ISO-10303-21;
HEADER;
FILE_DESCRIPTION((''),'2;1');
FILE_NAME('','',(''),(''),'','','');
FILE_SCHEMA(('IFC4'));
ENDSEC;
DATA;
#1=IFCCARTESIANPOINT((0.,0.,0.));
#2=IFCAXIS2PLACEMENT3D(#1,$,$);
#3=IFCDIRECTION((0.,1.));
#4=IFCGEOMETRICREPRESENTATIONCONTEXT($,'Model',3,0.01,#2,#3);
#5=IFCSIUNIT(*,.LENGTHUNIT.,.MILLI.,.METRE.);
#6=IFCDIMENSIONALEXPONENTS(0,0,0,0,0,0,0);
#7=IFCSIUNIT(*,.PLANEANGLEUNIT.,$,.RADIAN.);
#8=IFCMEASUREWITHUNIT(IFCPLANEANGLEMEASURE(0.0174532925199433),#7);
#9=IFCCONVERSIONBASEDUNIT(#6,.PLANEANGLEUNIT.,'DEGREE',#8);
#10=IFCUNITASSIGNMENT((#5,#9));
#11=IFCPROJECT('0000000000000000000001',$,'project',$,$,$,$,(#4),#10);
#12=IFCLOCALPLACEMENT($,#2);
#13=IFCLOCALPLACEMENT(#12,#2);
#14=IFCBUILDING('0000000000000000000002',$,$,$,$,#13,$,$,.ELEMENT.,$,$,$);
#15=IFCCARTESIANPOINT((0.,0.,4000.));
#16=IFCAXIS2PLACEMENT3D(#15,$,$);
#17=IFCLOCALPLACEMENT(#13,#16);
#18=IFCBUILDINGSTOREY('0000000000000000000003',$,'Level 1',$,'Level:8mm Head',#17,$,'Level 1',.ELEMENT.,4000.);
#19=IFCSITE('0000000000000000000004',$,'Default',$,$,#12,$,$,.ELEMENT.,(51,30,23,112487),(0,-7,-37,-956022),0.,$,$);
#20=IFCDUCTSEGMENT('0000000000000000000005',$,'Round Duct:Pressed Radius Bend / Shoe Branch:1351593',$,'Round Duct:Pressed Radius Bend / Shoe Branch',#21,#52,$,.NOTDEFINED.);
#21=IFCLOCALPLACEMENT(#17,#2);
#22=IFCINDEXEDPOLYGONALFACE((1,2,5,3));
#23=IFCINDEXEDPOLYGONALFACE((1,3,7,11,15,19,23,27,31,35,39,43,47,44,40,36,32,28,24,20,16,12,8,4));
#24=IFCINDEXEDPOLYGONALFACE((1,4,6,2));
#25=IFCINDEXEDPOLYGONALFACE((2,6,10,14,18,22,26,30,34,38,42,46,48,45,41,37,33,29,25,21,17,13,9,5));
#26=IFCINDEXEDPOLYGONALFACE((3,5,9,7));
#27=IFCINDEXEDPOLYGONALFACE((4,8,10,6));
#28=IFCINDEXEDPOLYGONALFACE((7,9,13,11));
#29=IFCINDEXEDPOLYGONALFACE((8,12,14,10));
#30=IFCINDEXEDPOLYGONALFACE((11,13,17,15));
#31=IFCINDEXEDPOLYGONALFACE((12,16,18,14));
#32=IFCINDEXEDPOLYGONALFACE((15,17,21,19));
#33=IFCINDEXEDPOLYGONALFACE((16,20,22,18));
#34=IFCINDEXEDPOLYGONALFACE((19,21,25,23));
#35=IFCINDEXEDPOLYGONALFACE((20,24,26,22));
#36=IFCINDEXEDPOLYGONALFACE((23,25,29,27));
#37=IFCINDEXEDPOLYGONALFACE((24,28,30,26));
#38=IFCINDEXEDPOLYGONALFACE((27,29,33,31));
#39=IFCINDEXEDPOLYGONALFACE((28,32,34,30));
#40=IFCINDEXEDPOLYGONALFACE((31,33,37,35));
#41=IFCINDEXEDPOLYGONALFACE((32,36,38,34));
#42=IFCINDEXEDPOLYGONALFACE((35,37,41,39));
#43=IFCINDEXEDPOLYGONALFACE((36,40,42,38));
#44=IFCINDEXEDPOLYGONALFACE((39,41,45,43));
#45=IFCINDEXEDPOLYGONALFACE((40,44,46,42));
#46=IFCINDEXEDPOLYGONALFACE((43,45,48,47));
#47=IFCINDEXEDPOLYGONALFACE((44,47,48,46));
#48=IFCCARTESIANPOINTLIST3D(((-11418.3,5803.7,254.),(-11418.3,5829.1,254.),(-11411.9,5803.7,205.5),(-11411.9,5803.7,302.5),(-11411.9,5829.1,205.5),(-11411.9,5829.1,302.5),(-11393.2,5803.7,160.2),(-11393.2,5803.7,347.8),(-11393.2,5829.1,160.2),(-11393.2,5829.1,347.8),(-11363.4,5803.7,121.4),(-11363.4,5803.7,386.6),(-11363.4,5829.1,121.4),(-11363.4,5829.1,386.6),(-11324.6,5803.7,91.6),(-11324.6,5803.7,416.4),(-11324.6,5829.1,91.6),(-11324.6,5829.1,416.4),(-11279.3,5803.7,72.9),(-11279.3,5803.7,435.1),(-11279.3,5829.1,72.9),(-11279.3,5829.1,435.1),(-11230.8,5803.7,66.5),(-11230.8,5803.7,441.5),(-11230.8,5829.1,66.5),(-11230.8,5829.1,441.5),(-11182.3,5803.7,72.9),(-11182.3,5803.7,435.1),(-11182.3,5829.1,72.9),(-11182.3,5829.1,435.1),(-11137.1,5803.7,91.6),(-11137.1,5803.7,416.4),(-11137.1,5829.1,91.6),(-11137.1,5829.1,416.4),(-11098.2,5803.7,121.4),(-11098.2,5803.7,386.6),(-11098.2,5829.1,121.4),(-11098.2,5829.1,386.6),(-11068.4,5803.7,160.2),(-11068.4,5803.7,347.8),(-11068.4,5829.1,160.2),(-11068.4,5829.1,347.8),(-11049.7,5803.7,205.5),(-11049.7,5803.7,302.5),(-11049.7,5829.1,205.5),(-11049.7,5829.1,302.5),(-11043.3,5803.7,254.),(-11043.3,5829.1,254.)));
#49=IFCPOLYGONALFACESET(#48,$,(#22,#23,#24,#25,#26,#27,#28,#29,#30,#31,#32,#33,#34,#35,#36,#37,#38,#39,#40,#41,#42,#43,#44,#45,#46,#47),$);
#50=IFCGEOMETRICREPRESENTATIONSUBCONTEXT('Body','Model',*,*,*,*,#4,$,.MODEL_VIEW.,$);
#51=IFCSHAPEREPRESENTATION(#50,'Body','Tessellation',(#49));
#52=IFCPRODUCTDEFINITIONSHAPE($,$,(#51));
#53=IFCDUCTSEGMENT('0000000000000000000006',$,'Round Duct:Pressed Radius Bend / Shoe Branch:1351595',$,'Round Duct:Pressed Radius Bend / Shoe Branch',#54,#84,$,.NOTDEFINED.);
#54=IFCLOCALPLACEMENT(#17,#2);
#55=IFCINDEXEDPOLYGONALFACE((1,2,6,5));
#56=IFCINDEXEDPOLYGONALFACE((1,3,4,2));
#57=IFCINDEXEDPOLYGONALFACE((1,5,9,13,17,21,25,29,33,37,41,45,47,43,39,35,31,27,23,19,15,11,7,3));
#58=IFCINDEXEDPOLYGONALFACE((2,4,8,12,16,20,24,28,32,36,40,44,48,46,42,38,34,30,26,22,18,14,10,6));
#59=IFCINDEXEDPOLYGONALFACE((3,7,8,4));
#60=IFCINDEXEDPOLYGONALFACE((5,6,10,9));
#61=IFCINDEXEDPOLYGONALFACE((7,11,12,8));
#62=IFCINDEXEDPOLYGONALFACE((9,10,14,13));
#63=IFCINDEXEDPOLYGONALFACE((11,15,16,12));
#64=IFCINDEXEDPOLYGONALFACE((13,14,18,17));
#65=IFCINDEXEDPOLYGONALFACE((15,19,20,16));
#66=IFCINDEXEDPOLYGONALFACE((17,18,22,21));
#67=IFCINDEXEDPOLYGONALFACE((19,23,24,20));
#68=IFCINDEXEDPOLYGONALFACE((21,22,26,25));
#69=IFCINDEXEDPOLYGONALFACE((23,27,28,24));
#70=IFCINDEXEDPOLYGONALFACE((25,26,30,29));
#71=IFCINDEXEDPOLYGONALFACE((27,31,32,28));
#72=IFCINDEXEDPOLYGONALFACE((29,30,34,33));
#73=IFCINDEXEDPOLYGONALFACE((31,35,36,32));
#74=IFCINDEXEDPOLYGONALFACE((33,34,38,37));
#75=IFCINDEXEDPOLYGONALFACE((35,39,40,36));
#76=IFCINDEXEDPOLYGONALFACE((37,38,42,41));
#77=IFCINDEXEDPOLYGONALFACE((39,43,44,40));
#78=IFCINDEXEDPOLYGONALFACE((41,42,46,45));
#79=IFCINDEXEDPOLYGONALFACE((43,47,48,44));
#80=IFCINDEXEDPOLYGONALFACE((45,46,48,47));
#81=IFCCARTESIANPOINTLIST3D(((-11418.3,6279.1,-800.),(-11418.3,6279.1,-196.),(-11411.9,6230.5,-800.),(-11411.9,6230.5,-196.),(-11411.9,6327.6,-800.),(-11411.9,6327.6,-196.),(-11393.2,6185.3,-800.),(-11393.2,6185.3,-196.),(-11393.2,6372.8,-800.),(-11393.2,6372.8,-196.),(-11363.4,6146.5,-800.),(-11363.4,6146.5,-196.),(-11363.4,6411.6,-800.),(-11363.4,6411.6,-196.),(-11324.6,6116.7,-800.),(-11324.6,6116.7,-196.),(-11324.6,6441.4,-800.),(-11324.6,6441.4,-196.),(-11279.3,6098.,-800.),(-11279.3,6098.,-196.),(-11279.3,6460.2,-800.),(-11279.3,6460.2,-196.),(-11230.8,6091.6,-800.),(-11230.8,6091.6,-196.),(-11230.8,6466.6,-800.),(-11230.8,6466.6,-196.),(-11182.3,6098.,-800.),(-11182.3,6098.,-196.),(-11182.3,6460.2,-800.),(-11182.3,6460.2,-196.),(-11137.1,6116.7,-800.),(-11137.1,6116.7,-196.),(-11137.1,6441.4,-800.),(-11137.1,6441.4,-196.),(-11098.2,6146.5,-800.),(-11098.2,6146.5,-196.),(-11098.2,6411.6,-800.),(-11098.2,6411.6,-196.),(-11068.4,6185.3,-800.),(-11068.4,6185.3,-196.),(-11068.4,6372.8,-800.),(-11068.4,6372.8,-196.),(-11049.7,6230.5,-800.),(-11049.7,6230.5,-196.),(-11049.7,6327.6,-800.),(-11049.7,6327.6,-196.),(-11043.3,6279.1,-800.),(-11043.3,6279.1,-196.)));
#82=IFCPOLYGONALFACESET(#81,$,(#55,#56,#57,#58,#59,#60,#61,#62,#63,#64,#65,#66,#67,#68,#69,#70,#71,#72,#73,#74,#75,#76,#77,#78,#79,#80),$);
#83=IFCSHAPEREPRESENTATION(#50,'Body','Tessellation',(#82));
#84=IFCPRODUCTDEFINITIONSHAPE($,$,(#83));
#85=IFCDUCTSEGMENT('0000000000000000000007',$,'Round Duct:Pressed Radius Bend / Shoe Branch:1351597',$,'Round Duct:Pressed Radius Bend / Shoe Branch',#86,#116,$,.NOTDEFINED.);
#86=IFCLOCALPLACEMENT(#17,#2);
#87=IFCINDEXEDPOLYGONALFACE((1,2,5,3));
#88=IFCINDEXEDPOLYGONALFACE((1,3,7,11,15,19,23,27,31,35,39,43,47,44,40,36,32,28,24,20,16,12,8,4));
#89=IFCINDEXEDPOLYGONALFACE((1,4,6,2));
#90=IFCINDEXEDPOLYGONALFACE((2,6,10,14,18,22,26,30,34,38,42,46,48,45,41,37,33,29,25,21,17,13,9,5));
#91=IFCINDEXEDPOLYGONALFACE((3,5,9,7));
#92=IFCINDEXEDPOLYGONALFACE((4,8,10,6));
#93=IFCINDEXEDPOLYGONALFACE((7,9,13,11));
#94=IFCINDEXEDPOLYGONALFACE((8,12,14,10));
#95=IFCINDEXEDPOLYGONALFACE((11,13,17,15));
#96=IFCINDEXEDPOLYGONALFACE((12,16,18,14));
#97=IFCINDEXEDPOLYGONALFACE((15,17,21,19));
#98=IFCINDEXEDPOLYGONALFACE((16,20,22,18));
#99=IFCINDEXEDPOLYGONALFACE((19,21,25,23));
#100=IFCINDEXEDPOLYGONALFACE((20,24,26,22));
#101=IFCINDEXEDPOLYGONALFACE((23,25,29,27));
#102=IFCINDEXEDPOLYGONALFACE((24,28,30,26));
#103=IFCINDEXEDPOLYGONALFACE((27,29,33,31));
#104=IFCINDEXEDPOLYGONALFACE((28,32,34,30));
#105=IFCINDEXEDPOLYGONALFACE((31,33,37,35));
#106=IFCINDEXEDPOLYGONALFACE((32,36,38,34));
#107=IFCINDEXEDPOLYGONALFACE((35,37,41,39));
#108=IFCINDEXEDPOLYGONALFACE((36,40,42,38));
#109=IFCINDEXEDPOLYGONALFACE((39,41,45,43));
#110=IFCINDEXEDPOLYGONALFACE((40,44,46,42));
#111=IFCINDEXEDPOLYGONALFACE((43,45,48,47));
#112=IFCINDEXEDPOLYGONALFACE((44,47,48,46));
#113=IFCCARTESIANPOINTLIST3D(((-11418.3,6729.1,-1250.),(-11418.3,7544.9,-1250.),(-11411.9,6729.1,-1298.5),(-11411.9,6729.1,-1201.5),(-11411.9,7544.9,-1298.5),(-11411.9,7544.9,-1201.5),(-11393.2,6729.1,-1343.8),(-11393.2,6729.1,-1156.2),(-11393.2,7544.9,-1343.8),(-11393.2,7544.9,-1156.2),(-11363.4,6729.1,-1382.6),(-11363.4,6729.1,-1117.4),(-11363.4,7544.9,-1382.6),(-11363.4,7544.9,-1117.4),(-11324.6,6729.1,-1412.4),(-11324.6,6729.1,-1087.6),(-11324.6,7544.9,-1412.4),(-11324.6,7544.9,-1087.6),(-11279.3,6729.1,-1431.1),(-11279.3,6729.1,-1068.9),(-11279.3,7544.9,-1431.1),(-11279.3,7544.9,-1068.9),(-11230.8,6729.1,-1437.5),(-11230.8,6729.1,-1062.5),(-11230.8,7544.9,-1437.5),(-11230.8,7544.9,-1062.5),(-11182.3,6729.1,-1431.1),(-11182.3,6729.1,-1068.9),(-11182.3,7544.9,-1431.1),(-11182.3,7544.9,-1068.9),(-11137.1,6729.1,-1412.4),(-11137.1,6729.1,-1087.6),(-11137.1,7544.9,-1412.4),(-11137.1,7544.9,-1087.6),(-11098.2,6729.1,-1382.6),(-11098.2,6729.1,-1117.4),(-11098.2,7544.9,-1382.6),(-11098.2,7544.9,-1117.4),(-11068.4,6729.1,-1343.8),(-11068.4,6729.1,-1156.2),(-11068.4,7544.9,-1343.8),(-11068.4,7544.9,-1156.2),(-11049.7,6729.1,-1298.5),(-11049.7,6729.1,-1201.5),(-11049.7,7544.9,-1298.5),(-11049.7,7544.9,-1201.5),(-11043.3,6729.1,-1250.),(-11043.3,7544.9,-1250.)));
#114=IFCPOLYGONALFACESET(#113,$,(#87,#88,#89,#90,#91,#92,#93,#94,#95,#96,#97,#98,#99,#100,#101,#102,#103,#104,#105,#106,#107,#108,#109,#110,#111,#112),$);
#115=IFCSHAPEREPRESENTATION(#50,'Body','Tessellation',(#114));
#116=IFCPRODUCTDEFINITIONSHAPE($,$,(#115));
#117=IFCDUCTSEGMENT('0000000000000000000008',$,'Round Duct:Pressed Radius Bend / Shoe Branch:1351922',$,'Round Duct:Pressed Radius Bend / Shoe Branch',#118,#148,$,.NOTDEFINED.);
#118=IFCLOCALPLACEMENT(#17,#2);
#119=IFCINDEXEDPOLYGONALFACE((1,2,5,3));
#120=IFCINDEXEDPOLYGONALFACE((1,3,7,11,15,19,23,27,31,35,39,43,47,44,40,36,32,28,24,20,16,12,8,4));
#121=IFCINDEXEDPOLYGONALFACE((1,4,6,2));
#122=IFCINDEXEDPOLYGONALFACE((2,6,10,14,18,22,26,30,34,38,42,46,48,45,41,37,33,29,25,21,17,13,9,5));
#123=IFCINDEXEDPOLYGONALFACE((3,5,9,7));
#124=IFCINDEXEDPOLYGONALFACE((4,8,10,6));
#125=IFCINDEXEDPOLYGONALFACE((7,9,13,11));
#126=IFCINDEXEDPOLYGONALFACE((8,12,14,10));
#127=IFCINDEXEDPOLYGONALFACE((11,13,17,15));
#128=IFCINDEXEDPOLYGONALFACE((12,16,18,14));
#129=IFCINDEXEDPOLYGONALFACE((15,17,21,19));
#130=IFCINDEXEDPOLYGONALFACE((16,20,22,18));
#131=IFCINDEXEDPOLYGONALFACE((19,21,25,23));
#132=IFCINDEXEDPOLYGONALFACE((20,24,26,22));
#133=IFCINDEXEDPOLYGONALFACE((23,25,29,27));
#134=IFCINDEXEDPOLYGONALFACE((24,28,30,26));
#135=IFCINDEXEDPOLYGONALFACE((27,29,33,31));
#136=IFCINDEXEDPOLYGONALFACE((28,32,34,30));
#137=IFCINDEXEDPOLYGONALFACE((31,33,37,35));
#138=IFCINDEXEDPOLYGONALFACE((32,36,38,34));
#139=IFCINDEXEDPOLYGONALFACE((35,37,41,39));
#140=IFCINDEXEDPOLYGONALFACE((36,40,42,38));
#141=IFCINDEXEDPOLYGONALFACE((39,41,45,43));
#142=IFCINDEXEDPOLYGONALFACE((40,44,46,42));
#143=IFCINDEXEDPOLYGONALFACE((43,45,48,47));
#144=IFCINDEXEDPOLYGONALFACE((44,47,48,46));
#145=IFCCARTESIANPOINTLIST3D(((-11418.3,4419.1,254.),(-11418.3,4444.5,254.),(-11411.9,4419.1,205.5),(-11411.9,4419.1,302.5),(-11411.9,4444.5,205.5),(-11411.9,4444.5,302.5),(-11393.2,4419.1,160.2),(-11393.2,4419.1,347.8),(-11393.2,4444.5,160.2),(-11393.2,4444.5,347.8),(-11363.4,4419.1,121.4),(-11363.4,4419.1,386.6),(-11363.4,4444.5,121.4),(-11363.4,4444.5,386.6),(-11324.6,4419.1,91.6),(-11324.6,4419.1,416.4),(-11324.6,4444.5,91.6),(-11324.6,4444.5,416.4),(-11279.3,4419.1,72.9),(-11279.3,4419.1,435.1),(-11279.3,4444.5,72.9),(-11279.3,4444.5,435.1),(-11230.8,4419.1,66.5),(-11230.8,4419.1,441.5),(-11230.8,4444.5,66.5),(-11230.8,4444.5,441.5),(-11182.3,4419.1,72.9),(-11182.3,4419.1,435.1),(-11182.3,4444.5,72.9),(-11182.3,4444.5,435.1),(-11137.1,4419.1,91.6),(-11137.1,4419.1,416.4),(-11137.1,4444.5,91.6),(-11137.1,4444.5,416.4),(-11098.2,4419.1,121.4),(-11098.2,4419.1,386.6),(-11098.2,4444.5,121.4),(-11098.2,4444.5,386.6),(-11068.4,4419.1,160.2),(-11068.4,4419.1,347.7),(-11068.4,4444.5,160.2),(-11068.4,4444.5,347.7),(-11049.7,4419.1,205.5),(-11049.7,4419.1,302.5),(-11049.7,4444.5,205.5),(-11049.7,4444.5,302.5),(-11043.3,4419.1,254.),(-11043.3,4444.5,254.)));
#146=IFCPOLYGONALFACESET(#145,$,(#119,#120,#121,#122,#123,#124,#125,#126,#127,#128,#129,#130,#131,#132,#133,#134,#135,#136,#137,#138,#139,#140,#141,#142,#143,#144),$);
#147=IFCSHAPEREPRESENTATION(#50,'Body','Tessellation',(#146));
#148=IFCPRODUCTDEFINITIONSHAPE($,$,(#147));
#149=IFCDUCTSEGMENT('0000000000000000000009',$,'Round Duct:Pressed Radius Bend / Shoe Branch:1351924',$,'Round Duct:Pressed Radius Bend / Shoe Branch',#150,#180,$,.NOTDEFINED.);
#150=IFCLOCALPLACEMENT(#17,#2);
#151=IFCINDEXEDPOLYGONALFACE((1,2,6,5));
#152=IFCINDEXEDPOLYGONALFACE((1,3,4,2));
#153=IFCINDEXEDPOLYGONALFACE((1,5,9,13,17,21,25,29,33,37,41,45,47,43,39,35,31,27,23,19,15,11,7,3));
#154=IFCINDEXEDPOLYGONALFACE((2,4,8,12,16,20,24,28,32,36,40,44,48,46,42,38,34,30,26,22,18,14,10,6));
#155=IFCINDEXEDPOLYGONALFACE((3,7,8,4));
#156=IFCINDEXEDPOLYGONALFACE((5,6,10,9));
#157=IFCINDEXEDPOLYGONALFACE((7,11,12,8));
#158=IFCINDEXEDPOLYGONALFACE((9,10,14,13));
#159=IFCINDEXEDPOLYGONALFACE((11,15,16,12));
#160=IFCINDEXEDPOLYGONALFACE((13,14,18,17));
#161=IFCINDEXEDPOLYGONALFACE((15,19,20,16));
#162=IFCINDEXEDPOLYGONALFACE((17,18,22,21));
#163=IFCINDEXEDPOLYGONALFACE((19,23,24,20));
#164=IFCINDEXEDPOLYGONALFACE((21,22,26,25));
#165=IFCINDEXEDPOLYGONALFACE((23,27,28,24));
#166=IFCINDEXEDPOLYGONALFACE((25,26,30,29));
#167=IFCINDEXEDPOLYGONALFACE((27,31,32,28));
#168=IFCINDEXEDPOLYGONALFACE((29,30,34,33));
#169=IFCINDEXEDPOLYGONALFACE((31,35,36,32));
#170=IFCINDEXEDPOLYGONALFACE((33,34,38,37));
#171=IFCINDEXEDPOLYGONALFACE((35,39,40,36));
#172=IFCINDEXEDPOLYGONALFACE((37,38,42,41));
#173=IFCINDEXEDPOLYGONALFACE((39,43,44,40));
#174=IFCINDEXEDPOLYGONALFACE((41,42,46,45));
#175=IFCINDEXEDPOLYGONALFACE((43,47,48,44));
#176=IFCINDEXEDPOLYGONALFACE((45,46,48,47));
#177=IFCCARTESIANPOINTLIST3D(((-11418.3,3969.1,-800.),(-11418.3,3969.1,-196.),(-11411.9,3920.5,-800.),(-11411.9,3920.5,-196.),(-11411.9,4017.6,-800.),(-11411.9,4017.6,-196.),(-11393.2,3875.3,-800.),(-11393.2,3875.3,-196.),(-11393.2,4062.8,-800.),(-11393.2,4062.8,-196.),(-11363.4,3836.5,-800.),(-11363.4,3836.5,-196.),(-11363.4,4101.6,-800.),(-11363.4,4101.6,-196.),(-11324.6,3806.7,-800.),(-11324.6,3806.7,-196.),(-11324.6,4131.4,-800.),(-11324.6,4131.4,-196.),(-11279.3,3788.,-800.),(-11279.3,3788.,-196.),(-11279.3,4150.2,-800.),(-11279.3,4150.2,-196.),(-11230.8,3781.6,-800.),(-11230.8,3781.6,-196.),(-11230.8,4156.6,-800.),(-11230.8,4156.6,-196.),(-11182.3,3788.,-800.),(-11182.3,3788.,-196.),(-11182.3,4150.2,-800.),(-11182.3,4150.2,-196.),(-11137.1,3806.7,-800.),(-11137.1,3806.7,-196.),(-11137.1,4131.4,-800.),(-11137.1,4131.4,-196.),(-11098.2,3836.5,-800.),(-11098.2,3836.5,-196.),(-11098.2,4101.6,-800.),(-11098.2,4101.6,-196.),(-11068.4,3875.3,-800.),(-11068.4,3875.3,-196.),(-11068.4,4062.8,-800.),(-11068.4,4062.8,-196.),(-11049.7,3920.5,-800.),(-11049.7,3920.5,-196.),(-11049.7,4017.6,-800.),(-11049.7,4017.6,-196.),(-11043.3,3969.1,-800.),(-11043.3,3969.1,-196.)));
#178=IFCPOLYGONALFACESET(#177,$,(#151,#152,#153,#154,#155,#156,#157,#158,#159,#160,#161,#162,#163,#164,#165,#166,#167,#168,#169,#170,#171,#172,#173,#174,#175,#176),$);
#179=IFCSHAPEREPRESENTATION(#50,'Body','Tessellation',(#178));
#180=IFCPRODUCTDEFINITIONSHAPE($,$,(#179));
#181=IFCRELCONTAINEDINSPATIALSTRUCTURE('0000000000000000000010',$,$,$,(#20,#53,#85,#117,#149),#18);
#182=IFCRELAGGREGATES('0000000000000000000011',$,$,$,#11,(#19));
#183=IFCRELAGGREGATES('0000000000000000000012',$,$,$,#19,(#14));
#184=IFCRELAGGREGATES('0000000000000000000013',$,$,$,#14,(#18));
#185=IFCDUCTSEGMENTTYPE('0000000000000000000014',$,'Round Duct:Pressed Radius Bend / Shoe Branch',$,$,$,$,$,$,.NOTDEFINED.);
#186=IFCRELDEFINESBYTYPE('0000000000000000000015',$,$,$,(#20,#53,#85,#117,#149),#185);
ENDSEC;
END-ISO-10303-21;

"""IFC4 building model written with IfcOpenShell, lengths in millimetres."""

from ifc_helpers import new_model, entity, si_unit, converted_unit, direction, frame, origin, place, context, subcontext, project, spatial, arc, indexed_curve, outline, extrude, type_object, element, save


model = new_model("IFC4")

# Units and contexts
model_context = context("Model", 3, precision=0.01, world=origin(), true_north=direction((0.0, 1.0)))
body_context = subcontext(model_context, "Body", "Model", "MODEL_VIEW")
ifc_project = project(units=[si_unit("LENGTHUNIT", "METRE", prefix="MILLI"), converted_unit("PLANEANGLEUNIT", "DEGREE", entity("IfcPlaneAngleMeasure", 0.0174532925199433), si_unit("PLANEANGLEUNIT", "RADIAN"), dimensions=[0, 0, 0, 0, 0, 0, 0])], contexts=[model_context])

# Site, building, storey
site_placement = place(None, origin())
site = spatial("IfcSite", under=ifc_project, at=site_placement, Name="Default", CompositionType="ELEMENT", RefLatitude=(51, 30, 23, 112487), RefLongitude=(0, -7, -37, -956022), RefElevation=0.0)
building_placement = place(site_placement, origin())
building = spatial("IfcBuilding", under=site, at=building_placement, CompositionType="ELEMENT")
storey_placement = place(building_placement, frame((0.0, 0.0, 4000.0)))
storey = spatial("IfcBuildingStorey", under=building, at=storey_placement, Name="Level 1", ObjectType="Level:8mm Head", LongName="Level 1", CompositionType="ELEMENT", Elevation=4000.0)

# Duct segments
duct_segment_type = type_object("IfcDuctSegmentType", Name="Round Duct:Pressed Radius Bend / Shoe Branch", PredefinedType="NOTDEFINED")
duct_segment_1_placement = place(storey_placement, origin())
element("IfcDuctSegment", 1, at=duct_segment_1_placement, inside=storey, type_object=duct_segment_type, Name="Round Duct:Pressed Radius Bend / Shoe Branch:1351593", ObjectType="Round Duct:Pressed Radius Bend / Shoe Branch", PredefinedType="NOTDEFINED", context=body_context, shape_type="SweptSolid", body=[
    extrude(outline(indexed_curve([(187.5, 0.0), (132.6, 132.6), (0.0, 187.5), (-132.6, 132.6), (-187.5, 0.0), (-132.6, -132.6), (0.0, -187.5), (132.6, -132.6)], segments=[arc(1, 2, 3), arc(3, 4, 5), arc(5, 6, 7), arc(7, 8, 1)], self_intersect=False)), frame((-11230.8, 5803.7, 254.0), z_axis=(0.0, 1.0, 0.0), x_axis=(1.0, 0.0, 0.0)), (0.0, 0.0, 1.0), 25.4),
])
duct_segment_2_placement = place(storey_placement, origin())
element("IfcDuctSegment", 2, at=duct_segment_2_placement, inside=storey, type_object=duct_segment_type, Name="Round Duct:Pressed Radius Bend / Shoe Branch:1351595", ObjectType="Round Duct:Pressed Radius Bend / Shoe Branch", PredefinedType="NOTDEFINED", context=body_context, shape_type="SweptSolid", body=[
    extrude(outline(indexed_curve([(187.5, 0.0), (132.6, 132.6), (0.0, 187.5), (-132.6, 132.6), (-187.5, 0.0), (-132.6, -132.6), (0.0, -187.5), (132.6, -132.6)], segments=[arc(1, 2, 3), arc(3, 4, 5), arc(5, 6, 7), arc(7, 8, 1)], self_intersect=False)), frame((-11230.8, 6279.1, -800.0)), (0.0, 0.0, 1.0), 604.0),
])
duct_segment_3_placement = place(storey_placement, origin())
element("IfcDuctSegment", 3, at=duct_segment_3_placement, inside=storey, type_object=duct_segment_type, Name="Round Duct:Pressed Radius Bend / Shoe Branch:1351597", ObjectType="Round Duct:Pressed Radius Bend / Shoe Branch", PredefinedType="NOTDEFINED", context=body_context, shape_type="SweptSolid", body=[
    extrude(outline(indexed_curve([(187.5, 0.0), (132.6, 132.6), (0.0, 187.5), (-132.6, 132.6), (-187.5, 0.0), (-132.6, -132.6), (0.0, -187.5), (132.6, -132.6)], segments=[arc(1, 2, 3), arc(3, 4, 5), arc(5, 6, 7), arc(7, 8, 1)], self_intersect=False)), frame((-11230.8, 6729.1, -1250.0), z_axis=(0.0, 1.0, 0.0), x_axis=(-1.0, 0.0, 0.0)), (0.0, 0.0, 1.0), 815.8),
])
duct_segment_4_placement = place(storey_placement, origin())
element("IfcDuctSegment", 4, at=duct_segment_4_placement, inside=storey, type_object=duct_segment_type, Name="Round Duct:Pressed Radius Bend / Shoe Branch:1351922", ObjectType="Round Duct:Pressed Radius Bend / Shoe Branch", PredefinedType="NOTDEFINED", context=body_context, shape_type="SweptSolid", body=[
    extrude(outline(indexed_curve([(187.5, 0.0), (132.6, 132.6), (0.0, 187.5), (-132.6, 132.6), (-187.5, 0.0), (-132.6, -132.6), (0.0, -187.5), (132.6, -132.6)], segments=[arc(1, 2, 3), arc(3, 4, 5), arc(5, 6, 7), arc(7, 8, 1)], self_intersect=False)), frame((-11230.8, 4419.1, 254.0), z_axis=(0.0, 1.0, 0.0), x_axis=(-1.0, 0.0, 0.0)), (0.0, 0.0, 1.0), 25.4),
])
duct_segment_5_placement = place(storey_placement, origin())
element("IfcDuctSegment", 5, at=duct_segment_5_placement, inside=storey, type_object=duct_segment_type, Name="Round Duct:Pressed Radius Bend / Shoe Branch:1351924", ObjectType="Round Duct:Pressed Radius Bend / Shoe Branch", PredefinedType="NOTDEFINED", context=body_context, shape_type="SweptSolid", body=[
    extrude(outline(indexed_curve([(187.5, 0.0), (132.6, 132.6), (0.0, 187.5), (-132.6, 132.6), (-187.5, 0.0), (-132.6, -132.6), (0.0, -187.5), (132.6, -132.6)], segments=[arc(1, 2, 3), arc(3, 4, 5), arc(5, 6, 7), arc(7, 8, 1)], self_intersect=False)), frame((-11230.8, 3969.1, -800.0), z_axis=(0.0, 0.0, 1.0), x_axis=(-1.0, 0.0, 0.0)), (0.0, 0.0, 1.0), 604.0),
])

save(model, "model.ifc")
